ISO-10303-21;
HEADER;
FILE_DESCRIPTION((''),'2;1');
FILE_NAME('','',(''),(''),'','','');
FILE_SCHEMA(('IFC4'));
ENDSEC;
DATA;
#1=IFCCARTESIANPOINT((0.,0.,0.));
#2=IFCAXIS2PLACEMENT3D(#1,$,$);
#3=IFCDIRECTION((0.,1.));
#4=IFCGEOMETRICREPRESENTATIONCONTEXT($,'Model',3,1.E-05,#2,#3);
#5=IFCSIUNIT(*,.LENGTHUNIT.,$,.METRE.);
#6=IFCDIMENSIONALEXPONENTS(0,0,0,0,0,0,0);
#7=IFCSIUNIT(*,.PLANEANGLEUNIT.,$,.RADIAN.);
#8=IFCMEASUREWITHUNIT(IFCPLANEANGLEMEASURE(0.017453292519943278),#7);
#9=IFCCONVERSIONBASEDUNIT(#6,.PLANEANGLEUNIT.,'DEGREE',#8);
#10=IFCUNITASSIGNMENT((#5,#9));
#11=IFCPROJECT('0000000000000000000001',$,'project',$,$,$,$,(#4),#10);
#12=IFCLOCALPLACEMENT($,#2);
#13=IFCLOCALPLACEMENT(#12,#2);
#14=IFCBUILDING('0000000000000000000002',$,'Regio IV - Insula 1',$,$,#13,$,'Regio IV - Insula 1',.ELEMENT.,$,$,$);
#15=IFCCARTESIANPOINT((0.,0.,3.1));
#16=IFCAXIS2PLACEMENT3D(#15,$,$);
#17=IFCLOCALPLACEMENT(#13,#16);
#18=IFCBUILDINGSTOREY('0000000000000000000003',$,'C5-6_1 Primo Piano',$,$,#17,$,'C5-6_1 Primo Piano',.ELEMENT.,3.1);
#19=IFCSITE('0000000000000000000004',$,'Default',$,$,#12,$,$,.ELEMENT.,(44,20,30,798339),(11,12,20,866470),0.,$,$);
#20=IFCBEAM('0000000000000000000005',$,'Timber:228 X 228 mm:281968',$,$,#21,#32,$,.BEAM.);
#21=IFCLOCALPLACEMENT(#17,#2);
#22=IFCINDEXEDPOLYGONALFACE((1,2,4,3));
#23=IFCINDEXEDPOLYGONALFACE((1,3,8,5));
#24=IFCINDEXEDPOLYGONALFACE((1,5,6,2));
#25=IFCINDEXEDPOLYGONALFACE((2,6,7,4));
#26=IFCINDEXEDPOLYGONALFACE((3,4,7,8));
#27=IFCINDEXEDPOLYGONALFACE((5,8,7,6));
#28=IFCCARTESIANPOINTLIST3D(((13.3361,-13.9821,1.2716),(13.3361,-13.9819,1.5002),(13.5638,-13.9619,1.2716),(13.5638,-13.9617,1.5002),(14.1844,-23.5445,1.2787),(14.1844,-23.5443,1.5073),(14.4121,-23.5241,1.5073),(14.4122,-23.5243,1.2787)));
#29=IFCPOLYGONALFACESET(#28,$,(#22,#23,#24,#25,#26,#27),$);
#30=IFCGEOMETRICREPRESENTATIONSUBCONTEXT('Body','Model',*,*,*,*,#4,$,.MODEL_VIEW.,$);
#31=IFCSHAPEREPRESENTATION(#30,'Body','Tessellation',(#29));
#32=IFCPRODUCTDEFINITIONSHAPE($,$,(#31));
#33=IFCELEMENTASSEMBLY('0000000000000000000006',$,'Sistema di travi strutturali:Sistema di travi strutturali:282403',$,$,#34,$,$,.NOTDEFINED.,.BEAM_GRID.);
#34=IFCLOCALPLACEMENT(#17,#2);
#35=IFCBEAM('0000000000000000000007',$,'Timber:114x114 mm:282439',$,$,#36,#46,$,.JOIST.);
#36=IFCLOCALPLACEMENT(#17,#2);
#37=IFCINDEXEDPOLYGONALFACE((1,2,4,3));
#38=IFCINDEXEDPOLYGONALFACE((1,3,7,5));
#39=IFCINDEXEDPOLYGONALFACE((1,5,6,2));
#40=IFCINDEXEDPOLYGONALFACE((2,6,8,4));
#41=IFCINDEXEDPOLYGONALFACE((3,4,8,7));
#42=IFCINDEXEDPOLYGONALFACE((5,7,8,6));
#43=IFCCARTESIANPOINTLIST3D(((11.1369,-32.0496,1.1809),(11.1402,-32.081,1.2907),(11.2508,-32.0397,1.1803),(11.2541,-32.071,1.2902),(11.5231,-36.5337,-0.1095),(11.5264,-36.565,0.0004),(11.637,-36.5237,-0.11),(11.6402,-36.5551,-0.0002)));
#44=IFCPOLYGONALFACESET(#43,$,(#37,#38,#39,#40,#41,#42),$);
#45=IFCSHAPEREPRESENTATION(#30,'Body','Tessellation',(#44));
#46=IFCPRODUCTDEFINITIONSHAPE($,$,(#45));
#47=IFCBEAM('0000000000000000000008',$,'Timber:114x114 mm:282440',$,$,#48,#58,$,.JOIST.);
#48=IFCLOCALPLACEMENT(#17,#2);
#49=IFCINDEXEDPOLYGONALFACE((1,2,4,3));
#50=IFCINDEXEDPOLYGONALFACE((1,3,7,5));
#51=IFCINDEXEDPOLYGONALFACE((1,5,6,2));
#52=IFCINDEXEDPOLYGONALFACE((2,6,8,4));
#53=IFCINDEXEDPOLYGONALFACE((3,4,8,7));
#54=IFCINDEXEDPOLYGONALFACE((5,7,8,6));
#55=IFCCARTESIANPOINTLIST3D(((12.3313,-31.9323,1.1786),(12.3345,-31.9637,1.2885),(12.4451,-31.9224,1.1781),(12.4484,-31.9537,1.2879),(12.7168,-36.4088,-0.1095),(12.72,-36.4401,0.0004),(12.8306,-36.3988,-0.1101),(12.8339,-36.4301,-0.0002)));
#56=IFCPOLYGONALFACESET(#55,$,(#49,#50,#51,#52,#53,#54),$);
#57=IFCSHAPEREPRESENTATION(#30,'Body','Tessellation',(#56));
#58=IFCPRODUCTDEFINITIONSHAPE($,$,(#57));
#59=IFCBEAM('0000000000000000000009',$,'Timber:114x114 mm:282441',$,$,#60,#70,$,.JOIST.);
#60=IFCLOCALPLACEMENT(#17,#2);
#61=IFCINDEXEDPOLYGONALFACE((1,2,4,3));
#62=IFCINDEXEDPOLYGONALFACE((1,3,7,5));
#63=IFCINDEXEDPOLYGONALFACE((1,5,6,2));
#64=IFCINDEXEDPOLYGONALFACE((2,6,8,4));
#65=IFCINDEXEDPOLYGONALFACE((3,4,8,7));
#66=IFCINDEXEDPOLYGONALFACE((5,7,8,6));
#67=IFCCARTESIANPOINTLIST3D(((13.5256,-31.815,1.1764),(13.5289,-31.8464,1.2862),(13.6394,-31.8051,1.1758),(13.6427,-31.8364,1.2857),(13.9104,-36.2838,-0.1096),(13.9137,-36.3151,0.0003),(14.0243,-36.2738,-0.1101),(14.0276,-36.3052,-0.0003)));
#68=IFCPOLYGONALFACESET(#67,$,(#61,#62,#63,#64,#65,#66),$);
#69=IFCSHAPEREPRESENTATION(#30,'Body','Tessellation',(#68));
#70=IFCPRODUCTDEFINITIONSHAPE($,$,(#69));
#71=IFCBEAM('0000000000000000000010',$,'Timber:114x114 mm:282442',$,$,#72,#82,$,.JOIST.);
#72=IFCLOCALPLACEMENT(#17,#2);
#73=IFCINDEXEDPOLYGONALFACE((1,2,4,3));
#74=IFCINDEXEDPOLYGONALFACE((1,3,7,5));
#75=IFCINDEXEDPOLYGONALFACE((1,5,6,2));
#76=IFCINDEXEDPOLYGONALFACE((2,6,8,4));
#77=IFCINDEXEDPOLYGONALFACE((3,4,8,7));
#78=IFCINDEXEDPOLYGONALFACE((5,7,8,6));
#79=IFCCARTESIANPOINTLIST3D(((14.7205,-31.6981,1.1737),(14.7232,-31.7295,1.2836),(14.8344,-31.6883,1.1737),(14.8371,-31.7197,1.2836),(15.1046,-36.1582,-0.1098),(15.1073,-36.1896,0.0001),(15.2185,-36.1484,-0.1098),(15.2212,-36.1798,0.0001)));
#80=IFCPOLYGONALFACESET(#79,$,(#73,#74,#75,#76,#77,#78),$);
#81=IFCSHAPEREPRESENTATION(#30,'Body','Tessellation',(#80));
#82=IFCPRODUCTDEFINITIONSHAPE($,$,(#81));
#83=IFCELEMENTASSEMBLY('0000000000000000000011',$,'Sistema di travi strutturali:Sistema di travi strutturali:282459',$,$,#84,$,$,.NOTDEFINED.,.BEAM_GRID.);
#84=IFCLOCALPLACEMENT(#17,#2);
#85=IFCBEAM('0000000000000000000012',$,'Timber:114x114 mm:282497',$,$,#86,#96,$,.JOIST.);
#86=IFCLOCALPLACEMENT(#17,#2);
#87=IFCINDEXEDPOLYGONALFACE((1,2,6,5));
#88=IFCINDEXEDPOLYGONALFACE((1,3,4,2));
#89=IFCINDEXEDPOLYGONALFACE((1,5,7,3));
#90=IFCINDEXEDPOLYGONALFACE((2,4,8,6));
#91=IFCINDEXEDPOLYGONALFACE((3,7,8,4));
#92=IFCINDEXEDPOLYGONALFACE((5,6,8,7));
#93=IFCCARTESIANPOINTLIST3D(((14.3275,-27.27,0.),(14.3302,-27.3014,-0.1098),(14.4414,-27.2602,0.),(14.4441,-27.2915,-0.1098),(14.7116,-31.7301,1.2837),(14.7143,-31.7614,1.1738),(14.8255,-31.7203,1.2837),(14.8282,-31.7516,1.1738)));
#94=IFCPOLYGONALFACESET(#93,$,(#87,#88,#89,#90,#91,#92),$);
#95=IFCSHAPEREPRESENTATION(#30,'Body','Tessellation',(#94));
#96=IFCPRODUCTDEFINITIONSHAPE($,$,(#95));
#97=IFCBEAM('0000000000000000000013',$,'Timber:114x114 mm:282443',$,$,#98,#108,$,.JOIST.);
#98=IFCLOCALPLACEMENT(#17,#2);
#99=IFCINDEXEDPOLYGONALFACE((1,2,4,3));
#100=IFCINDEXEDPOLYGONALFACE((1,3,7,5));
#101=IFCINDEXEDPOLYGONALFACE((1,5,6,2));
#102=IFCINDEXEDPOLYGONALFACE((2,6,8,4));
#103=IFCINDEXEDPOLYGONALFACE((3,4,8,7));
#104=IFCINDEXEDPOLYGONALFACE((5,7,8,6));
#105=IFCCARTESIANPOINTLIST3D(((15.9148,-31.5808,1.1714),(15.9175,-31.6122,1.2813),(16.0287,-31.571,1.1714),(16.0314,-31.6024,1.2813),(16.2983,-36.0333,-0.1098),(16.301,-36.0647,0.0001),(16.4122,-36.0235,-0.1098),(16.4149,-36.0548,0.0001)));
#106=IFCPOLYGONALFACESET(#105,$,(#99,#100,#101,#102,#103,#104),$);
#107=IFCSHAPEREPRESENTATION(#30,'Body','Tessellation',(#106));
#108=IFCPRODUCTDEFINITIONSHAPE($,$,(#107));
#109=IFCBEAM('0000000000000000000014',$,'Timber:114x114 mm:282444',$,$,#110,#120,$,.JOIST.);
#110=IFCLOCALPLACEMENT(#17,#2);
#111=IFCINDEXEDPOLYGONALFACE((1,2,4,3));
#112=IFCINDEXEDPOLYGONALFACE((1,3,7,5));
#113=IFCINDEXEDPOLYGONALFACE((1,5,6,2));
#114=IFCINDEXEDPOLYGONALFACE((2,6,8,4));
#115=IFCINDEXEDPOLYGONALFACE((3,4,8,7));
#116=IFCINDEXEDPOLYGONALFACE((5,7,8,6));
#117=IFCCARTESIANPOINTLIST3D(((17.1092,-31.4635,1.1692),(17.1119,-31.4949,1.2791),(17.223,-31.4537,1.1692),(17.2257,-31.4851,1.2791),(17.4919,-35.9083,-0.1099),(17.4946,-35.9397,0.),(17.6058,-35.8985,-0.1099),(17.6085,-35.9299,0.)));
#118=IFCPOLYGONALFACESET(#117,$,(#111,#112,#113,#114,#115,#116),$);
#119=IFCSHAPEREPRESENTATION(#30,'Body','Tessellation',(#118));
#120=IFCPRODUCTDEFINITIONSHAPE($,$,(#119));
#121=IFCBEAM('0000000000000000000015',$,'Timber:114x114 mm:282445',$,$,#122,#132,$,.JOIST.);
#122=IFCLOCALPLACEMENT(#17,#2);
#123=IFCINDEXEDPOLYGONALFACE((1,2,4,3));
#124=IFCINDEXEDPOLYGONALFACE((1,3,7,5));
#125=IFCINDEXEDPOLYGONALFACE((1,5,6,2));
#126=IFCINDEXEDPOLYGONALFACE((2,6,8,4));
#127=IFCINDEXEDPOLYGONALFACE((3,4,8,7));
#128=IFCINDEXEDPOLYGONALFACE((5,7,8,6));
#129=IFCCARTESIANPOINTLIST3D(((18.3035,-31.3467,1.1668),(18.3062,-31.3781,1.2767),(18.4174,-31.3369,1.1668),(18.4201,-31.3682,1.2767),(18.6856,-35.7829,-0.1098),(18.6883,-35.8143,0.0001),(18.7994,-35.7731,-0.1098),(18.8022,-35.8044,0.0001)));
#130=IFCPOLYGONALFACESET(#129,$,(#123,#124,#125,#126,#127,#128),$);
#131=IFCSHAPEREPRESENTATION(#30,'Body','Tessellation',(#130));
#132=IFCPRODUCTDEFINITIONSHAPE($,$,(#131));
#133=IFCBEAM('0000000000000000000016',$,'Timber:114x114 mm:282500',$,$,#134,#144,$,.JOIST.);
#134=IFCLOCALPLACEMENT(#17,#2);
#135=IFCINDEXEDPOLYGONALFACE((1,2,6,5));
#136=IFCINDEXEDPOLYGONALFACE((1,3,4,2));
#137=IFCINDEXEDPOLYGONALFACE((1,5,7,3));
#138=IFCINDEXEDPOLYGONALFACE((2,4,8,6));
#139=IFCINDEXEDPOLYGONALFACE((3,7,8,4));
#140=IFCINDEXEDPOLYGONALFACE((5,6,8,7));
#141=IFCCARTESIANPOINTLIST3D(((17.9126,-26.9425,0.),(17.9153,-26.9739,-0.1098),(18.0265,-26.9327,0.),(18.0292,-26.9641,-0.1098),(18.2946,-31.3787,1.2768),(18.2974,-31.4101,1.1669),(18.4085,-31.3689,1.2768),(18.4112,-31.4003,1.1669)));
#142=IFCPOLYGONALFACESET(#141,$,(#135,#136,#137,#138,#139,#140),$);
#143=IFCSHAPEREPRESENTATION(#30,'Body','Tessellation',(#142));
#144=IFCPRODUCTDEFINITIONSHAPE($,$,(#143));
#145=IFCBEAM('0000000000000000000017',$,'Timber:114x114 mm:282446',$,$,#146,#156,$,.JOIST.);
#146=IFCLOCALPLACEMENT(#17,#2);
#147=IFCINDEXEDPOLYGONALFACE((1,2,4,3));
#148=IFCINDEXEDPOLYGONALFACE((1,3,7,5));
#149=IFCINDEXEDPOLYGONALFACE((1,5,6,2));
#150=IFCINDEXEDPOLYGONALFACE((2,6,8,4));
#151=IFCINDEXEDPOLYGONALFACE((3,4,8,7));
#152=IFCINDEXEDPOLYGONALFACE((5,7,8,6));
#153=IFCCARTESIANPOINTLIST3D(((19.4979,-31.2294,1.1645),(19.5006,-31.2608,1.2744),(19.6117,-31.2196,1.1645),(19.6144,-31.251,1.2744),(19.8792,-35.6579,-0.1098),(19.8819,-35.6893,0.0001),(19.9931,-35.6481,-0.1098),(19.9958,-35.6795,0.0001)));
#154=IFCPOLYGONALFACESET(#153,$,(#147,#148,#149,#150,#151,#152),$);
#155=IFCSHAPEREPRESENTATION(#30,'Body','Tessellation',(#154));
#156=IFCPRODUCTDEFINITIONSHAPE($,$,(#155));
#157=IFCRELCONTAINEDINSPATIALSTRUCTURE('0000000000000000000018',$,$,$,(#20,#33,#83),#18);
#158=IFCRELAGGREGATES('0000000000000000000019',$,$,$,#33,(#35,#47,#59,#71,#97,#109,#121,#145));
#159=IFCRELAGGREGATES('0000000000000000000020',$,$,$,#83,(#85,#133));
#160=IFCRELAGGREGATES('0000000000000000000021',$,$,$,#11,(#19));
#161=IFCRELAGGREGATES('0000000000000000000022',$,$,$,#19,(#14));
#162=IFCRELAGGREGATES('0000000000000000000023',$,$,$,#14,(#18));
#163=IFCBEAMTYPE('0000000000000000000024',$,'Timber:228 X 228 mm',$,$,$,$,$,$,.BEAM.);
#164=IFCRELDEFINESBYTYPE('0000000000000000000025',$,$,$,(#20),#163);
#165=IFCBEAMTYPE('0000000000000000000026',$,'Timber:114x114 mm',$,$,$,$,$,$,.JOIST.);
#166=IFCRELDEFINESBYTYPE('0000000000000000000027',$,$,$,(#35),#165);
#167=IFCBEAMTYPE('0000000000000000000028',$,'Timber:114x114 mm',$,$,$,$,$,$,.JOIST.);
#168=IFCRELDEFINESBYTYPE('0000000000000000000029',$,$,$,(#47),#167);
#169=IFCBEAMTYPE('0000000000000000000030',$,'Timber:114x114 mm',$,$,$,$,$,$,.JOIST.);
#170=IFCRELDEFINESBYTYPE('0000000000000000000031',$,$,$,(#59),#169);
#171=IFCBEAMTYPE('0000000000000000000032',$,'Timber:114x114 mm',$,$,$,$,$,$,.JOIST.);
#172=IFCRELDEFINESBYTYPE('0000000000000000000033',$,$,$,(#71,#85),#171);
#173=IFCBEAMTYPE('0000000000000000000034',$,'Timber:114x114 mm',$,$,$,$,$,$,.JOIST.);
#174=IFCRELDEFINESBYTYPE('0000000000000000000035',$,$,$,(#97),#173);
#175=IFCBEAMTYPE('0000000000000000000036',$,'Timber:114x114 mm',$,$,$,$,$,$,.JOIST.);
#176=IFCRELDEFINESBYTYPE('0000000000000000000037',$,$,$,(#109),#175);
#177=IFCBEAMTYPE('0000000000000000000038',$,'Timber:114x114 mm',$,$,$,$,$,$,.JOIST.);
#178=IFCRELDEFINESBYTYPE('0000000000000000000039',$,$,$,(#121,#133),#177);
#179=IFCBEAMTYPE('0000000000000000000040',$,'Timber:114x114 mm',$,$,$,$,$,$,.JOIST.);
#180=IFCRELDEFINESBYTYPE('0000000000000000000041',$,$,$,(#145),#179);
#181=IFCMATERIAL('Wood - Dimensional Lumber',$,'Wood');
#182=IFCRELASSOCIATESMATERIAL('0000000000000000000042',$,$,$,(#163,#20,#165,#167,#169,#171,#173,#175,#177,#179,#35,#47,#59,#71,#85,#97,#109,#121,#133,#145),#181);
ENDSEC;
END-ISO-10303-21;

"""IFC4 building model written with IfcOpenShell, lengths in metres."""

from ifc_helpers import new_model, entity, si_unit, converted_unit, direction, frame, frame_2d, origin, origin_2d_with_axis, place, context, subcontext, project, spatial, rectangle, extrude, source, transform, mapped, material, material_profile, profile_set, profile_usage, type_object, type_shapes, element, aggregate, save


model = new_model("IFC4")

# Units and contexts
model_context = context("Model", 3, precision=1e-05, world=origin(), true_north=direction((0.0, 1.0)))
body_context = subcontext(model_context, "Body", "Model", "MODEL_VIEW")
ifc_project = project(units=[si_unit("LENGTHUNIT", "METRE"), converted_unit("PLANEANGLEUNIT", "DEGREE", entity("IfcPlaneAngleMeasure", 0.017453292519943278), si_unit("PLANEANGLEUNIT", "RADIAN"), dimensions=[0, 0, 0, 0, 0, 0, 0])], contexts=[model_context])

# Site, building, storey
site_placement = place(None, origin())
site = spatial("IfcSite", under=ifc_project, at=site_placement, Name="Default", CompositionType="ELEMENT", RefLatitude=(44, 20, 30, 798339), RefLongitude=(11, 12, 20, 866470), RefElevation=0.0)
building_placement = place(site_placement, origin())
building = spatial("IfcBuilding", under=site, at=building_placement, Name="Regio IV - Insula 1", LongName="Regio IV - Insula 1", CompositionType="ELEMENT")
storey_placement = place(building_placement, frame((0.0, 0.0, 3.1)))
storey = spatial("IfcBuildingStorey", under=building, at=storey_placement, Name="C5-6_1 Primo Piano", LongName="C5-6_1 Primo Piano", CompositionType="ELEMENT", Elevation=3.1)

# Shared definitions
ifc_material = material(Name="Wood - Dimensional Lumber", Category="Wood")
ifc_material_profile_1 = material_profile(ifc_material, rectangle(XDim=5.294, YDim=0.1143, at=origin_2d_with_axis()), Name="114x114 mm")
ifc_profile_set_1 = profile_set([ifc_material_profile_1], Name="114x114 mm")
ifc_profile_usage_1 = profile_usage(ifc_profile_set_1, cardinal=8)

# Beam
ifc_material_profile_2 = material_profile(ifc_material, rectangle(XDim=8.091, YDim=0.2286, at=frame_2d((0.0, 0.0), x_axis=(1.0, 0.0))), Name="228 X 228 mm")
ifc_profile_set_2 = profile_set([ifc_material_profile_2], Name="228 X 228 mm")
ifc_profile_usage_2 = profile_usage(ifc_profile_set_2, cardinal=1)
beam_type_1 = type_object("IfcBeamType", Name="Timber:228 X 228 mm", PredefinedType="BEAM", material=ifc_profile_set_2)
shared_shape_1 = source(origin(), body_context, "Body", "SweptSolid", [
    extrude(rectangle(XDim=9.6, YDim=0.2286, at=origin_2d_with_axis()), frame((0.0, 0.0, -0.1143), z_axis=(0.0, 0.0, 1.0), x_axis=(-1.0, 0.0, 0.0)), (0.0, 0.0, 1.0), 0.2286),
])
type_shapes(beam_type_1, [shared_shape_1])
beam_1_placement = place(storey_placement, frame((13.8741, -18.7531, 1.3895), z_axis=(-0.000065, 0.000737, 1.0), x_axis=(-0.088371, 0.996087, -0.00074)))
element("IfcBeam", 1, at=beam_1_placement, inside=storey, type_object=beam_type_1, material=ifc_profile_usage_2, Name="Timber:228 X 228 mm:281968", PredefinedType="BEAM", context=body_context, shape_type="MappedRepresentation", body=[
    mapped(shared_shape_1, transform((0.0, 0.0, 0.0), scale=1.0)),
])

# Element assembly, beams
assembly_1_placement = place(storey_placement, origin())
assembly_1 = element("IfcElementAssembly", 2, at=assembly_1_placement, inside=storey, Name="Sistema di travi strutturali:Sistema di travi strutturali:282403", AssemblyPlace="NOTDEFINED", PredefinedType="BEAM_GRID")
beam_type_2 = type_object("IfcBeamType", Name="Timber:114x114 mm", PredefinedType="JOIST", material=ifc_profile_set_1)
shared_shape_2 = source(origin(), body_context, "Body", "SweptSolid", [
    extrude(rectangle(XDim=4.682, YDim=0.1143, at=origin_2d_with_axis()), frame((0.0, 0.0, -0.0572), z_axis=(0.0, 0.0, 1.0), x_axis=(-1.0, 0.0, 0.0)), (0.0, 0.0, 1.0), 0.1143),
])
type_shapes(beam_type_2, [shared_shape_2])
beam_2_placement = place(assembly_1_placement, frame((11.3886, -34.3024, 0.5904), z_axis=(0.028737, -0.274135, 0.961262), x_axis=(0.082478, -0.957729, -0.275594)))
beam_2 = element("IfcBeam", 3, at=beam_2_placement, type_object=beam_type_2, material=ifc_profile_usage_1, Name="Timber:114x114 mm:282439", PredefinedType="JOIST", context=body_context, shape_type="MappedRepresentation", body=[
    mapped(shared_shape_2, transform((0.0, 0.0, 0.0), scale=1.0)),
])
beam_type_3 = type_object("IfcBeamType", Name="Timber:114x114 mm", PredefinedType="JOIST", material=ifc_profile_set_1)
shared_shape_3 = source(origin(), body_context, "Body", "SweptSolid", [
    extrude(rectangle(XDim=4.674, YDim=0.1143, at=origin_2d_with_axis()), frame((0.0, 0.0, -0.0572), z_axis=(0.0, 0.0, 1.0), x_axis=(-1.0, 0.0, 0.0)), (0.0, 0.0, 1.0), 0.1143),
])
type_shapes(beam_type_3, [shared_shape_3])
beam_3_placement = place(assembly_1_placement, frame((12.5826, -34.1812, 0.5892), z_axis=(0.028737, -0.274135, 0.961262), x_axis=(0.082478, -0.957729, -0.275594)))
beam_3 = element("IfcBeam", 4, at=beam_3_placement, type_object=beam_type_3, material=ifc_profile_usage_1, Name="Timber:114x114 mm:282440", PredefinedType="JOIST", context=body_context, shape_type="MappedRepresentation", body=[
    mapped(shared_shape_3, transform((0.0, 0.0, 0.0), scale=1.0)),
])
beam_type_4 = type_object("IfcBeamType", Name="Timber:114x114 mm", PredefinedType="JOIST", material=ifc_profile_set_1)
shared_shape_4 = source(origin(), body_context, "Body", "SweptSolid", [
    extrude(rectangle(XDim=4.666, YDim=0.1143, at=origin_2d_with_axis()), frame((0.0, 0.0, -0.0572), z_axis=(0.0, 0.0, 1.0), x_axis=(-1.0, 0.0, 0.0)), (0.0, 0.0, 1.0), 0.1143),
])
type_shapes(beam_type_4, [shared_shape_4])
beam_4_placement = place(assembly_1_placement, frame((13.7766, -34.0601, 0.5881), z_axis=(0.028737, -0.274135, 0.961262), x_axis=(0.082478, -0.957729, -0.275594)))
beam_4 = element("IfcBeam", 5, at=beam_4_placement, type_object=beam_type_4, material=ifc_profile_usage_1, Name="Timber:114x114 mm:282441", PredefinedType="JOIST", context=body_context, shape_type="MappedRepresentation", body=[
    mapped(shared_shape_4, transform((0.0, 0.0, 0.0), scale=1.0)),
])
beam_type_5 = type_object("IfcBeamType", Name="Timber:114x114 mm", PredefinedType="JOIST", material=ifc_profile_set_1)
shared_shape_5 = source(origin(), body_context, "Body", "SweptSolid", [
    extrude(rectangle(XDim=4.657, YDim=0.1143, at=origin_2d_with_axis()), frame((0.0, 0.0, -0.0572), z_axis=(0.0, 0.0, 1.0), x_axis=(-1.0, 0.0, 0.0)), (0.0, 0.0, 1.0), 0.1143),
])
type_shapes(beam_type_5, [shared_shape_5])
beam_5_placement = place(assembly_1_placement, frame((14.9709, -33.9389, 0.5869), z_axis=(0.023646, -0.274577, 0.961274), x_axis=(0.082478, -0.957729, -0.275594)))
beam_5 = element("IfcBeam", 6, at=beam_5_placement, type_object=beam_type_5, material=ifc_profile_usage_1, Name="Timber:114x114 mm:282442", PredefinedType="JOIST", context=body_context, shape_type="MappedRepresentation", body=[
    mapped(shared_shape_5, transform((0.0, 0.0, 0.0), scale=1.0)),
])

# Element assembly, beam
assembly_2_placement = place(storey_placement, origin())
assembly_2 = element("IfcElementAssembly", 7, at=assembly_2_placement, inside=storey, Name="Sistema di travi strutturali:Sistema di travi strutturali:282459", AssemblyPlace="NOTDEFINED", PredefinedType="BEAM_GRID")
beam_6_placement = place(assembly_2_placement, frame((14.5778, -29.5108, 0.5869), z_axis=(-0.02365, 0.274618, 0.961263), x_axis=(0.082477, -0.957718, 0.275634)))
beam_6 = element("IfcBeam", 8, at=beam_6_placement, type_object=beam_type_5, material=ifc_profile_usage_1, Name="Timber:114x114 mm:282497", PredefinedType="JOIST", context=body_context, shape_type="MappedRepresentation", body=[
    mapped(shared_shape_5, transform((0.0, 0.0, 0.0), scale=1.0)),
])

# Beams
beam_type_6 = type_object("IfcBeamType", Name="Timber:114x114 mm", PredefinedType="JOIST", material=ifc_profile_set_1)
shared_shape_6 = source(origin(), body_context, "Body", "SweptSolid", [
    extrude(rectangle(XDim=4.649, YDim=0.1143, at=origin_2d_with_axis()), frame((0.0, 0.0, -0.0572), z_axis=(0.0, 0.0, 1.0), x_axis=(-1.0, 0.0, 0.0)), (0.0, 0.0, 1.0), 0.1143),
])
type_shapes(beam_type_6, [shared_shape_6])
beam_7_placement = place(assembly_1_placement, frame((16.1649, -33.8178, 0.5858), z_axis=(0.023646, -0.274577, 0.961274), x_axis=(0.082478, -0.957729, -0.275594)))
beam_7 = element("IfcBeam", 9, at=beam_7_placement, type_object=beam_type_6, material=ifc_profile_usage_1, Name="Timber:114x114 mm:282443", PredefinedType="JOIST", context=body_context, shape_type="MappedRepresentation", body=[
    mapped(shared_shape_6, transform((0.0, 0.0, 0.0), scale=1.0)),
])
beam_type_7 = type_object("IfcBeamType", Name="Timber:114x114 mm", PredefinedType="JOIST", material=ifc_profile_set_1)
shared_shape_7 = source(origin(), body_context, "Body", "SweptSolid", [
    extrude(rectangle(XDim=4.641, YDim=0.1143, at=origin_2d_with_axis()), frame((0.0, 0.0, -0.0572), z_axis=(0.0, 0.0, 1.0), x_axis=(-1.0, 0.0, 0.0)), (0.0, 0.0, 1.0), 0.1143),
])
type_shapes(beam_type_7, [shared_shape_7])
beam_8_placement = place(assembly_1_placement, frame((17.3588, -33.6967, 0.5846), z_axis=(0.023646, -0.274577, 0.961274), x_axis=(0.082478, -0.957729, -0.275594)))
beam_8 = element("IfcBeam", 10, at=beam_8_placement, type_object=beam_type_7, material=ifc_profile_usage_1, Name="Timber:114x114 mm:282444", PredefinedType="JOIST", context=body_context, shape_type="MappedRepresentation", body=[
    mapped(shared_shape_7, transform((0.0, 0.0, 0.0), scale=1.0)),
])
beam_type_8 = type_object("IfcBeamType", Name="Timber:114x114 mm", PredefinedType="JOIST", material=ifc_profile_set_1)
shared_shape_8 = source(origin(), body_context, "Body", "SweptSolid", [
    extrude(rectangle(XDim=4.632, YDim=0.1143, at=origin_2d_with_axis()), frame((0.0, 0.0, -0.0572), z_axis=(0.0, 0.0, 1.0), x_axis=(-1.0, 0.0, 0.0)), (0.0, 0.0, 1.0), 0.1143),
])
type_shapes(beam_type_8, [shared_shape_8])
beam_9_placement = place(assembly_1_placement, frame((18.5528, -33.5756, 0.5834), z_axis=(0.023646, -0.274577, 0.961274), x_axis=(0.082478, -0.957729, -0.275594)))
beam_9 = element("IfcBeam", 11, at=beam_9_placement, type_object=beam_type_8, material=ifc_profile_usage_1, Name="Timber:114x114 mm:282445", PredefinedType="JOIST", context=body_context, shape_type="MappedRepresentation", body=[
    mapped(shared_shape_8, transform((0.0, 0.0, 0.0), scale=1.0)),
])
beam_10_placement = place(assembly_2_placement, frame((18.1619, -29.1714, 0.5835), z_axis=(-0.02365, 0.274618, 0.961263), x_axis=(0.082477, -0.957718, 0.275634)))
beam_10 = element("IfcBeam", 12, at=beam_10_placement, type_object=beam_type_8, material=ifc_profile_usage_1, Name="Timber:114x114 mm:282500", PredefinedType="JOIST", context=body_context, shape_type="MappedRepresentation", body=[
    mapped(shared_shape_8, transform((0.0, 0.0, 0.0), scale=1.0)),
])
beam_type_9 = type_object("IfcBeamType", Name="Timber:114x114 mm", PredefinedType="JOIST", material=ifc_profile_set_1)
shared_shape_9 = source(origin(), body_context, "Body", "SweptSolid", [
    extrude(rectangle(XDim=4.624, YDim=0.1143, at=origin_2d_with_axis()), frame((0.0, 0.0, -0.0572), z_axis=(0.0, 0.0, 1.0), x_axis=(-1.0, 0.0, 0.0)), (0.0, 0.0, 1.0), 0.1143),
])
type_shapes(beam_type_9, [shared_shape_9])
beam_11_placement = place(assembly_1_placement, frame((19.7468, -33.4544, 0.5823), z_axis=(0.023646, -0.274577, 0.961274), x_axis=(0.082478, -0.957729, -0.275594)))
beam_11 = element("IfcBeam", 13, at=beam_11_placement, type_object=beam_type_9, material=ifc_profile_usage_1, Name="Timber:114x114 mm:282446", PredefinedType="JOIST", context=body_context, shape_type="MappedRepresentation", body=[
    mapped(shared_shape_9, transform((0.0, 0.0, 0.0), scale=1.0)),
])
aggregate(assembly_1, [beam_2, beam_3, beam_4, beam_5, beam_7, beam_8, beam_9, beam_11])
aggregate(assembly_2, [beam_6, beam_10])

save(model, "model.ifc")
